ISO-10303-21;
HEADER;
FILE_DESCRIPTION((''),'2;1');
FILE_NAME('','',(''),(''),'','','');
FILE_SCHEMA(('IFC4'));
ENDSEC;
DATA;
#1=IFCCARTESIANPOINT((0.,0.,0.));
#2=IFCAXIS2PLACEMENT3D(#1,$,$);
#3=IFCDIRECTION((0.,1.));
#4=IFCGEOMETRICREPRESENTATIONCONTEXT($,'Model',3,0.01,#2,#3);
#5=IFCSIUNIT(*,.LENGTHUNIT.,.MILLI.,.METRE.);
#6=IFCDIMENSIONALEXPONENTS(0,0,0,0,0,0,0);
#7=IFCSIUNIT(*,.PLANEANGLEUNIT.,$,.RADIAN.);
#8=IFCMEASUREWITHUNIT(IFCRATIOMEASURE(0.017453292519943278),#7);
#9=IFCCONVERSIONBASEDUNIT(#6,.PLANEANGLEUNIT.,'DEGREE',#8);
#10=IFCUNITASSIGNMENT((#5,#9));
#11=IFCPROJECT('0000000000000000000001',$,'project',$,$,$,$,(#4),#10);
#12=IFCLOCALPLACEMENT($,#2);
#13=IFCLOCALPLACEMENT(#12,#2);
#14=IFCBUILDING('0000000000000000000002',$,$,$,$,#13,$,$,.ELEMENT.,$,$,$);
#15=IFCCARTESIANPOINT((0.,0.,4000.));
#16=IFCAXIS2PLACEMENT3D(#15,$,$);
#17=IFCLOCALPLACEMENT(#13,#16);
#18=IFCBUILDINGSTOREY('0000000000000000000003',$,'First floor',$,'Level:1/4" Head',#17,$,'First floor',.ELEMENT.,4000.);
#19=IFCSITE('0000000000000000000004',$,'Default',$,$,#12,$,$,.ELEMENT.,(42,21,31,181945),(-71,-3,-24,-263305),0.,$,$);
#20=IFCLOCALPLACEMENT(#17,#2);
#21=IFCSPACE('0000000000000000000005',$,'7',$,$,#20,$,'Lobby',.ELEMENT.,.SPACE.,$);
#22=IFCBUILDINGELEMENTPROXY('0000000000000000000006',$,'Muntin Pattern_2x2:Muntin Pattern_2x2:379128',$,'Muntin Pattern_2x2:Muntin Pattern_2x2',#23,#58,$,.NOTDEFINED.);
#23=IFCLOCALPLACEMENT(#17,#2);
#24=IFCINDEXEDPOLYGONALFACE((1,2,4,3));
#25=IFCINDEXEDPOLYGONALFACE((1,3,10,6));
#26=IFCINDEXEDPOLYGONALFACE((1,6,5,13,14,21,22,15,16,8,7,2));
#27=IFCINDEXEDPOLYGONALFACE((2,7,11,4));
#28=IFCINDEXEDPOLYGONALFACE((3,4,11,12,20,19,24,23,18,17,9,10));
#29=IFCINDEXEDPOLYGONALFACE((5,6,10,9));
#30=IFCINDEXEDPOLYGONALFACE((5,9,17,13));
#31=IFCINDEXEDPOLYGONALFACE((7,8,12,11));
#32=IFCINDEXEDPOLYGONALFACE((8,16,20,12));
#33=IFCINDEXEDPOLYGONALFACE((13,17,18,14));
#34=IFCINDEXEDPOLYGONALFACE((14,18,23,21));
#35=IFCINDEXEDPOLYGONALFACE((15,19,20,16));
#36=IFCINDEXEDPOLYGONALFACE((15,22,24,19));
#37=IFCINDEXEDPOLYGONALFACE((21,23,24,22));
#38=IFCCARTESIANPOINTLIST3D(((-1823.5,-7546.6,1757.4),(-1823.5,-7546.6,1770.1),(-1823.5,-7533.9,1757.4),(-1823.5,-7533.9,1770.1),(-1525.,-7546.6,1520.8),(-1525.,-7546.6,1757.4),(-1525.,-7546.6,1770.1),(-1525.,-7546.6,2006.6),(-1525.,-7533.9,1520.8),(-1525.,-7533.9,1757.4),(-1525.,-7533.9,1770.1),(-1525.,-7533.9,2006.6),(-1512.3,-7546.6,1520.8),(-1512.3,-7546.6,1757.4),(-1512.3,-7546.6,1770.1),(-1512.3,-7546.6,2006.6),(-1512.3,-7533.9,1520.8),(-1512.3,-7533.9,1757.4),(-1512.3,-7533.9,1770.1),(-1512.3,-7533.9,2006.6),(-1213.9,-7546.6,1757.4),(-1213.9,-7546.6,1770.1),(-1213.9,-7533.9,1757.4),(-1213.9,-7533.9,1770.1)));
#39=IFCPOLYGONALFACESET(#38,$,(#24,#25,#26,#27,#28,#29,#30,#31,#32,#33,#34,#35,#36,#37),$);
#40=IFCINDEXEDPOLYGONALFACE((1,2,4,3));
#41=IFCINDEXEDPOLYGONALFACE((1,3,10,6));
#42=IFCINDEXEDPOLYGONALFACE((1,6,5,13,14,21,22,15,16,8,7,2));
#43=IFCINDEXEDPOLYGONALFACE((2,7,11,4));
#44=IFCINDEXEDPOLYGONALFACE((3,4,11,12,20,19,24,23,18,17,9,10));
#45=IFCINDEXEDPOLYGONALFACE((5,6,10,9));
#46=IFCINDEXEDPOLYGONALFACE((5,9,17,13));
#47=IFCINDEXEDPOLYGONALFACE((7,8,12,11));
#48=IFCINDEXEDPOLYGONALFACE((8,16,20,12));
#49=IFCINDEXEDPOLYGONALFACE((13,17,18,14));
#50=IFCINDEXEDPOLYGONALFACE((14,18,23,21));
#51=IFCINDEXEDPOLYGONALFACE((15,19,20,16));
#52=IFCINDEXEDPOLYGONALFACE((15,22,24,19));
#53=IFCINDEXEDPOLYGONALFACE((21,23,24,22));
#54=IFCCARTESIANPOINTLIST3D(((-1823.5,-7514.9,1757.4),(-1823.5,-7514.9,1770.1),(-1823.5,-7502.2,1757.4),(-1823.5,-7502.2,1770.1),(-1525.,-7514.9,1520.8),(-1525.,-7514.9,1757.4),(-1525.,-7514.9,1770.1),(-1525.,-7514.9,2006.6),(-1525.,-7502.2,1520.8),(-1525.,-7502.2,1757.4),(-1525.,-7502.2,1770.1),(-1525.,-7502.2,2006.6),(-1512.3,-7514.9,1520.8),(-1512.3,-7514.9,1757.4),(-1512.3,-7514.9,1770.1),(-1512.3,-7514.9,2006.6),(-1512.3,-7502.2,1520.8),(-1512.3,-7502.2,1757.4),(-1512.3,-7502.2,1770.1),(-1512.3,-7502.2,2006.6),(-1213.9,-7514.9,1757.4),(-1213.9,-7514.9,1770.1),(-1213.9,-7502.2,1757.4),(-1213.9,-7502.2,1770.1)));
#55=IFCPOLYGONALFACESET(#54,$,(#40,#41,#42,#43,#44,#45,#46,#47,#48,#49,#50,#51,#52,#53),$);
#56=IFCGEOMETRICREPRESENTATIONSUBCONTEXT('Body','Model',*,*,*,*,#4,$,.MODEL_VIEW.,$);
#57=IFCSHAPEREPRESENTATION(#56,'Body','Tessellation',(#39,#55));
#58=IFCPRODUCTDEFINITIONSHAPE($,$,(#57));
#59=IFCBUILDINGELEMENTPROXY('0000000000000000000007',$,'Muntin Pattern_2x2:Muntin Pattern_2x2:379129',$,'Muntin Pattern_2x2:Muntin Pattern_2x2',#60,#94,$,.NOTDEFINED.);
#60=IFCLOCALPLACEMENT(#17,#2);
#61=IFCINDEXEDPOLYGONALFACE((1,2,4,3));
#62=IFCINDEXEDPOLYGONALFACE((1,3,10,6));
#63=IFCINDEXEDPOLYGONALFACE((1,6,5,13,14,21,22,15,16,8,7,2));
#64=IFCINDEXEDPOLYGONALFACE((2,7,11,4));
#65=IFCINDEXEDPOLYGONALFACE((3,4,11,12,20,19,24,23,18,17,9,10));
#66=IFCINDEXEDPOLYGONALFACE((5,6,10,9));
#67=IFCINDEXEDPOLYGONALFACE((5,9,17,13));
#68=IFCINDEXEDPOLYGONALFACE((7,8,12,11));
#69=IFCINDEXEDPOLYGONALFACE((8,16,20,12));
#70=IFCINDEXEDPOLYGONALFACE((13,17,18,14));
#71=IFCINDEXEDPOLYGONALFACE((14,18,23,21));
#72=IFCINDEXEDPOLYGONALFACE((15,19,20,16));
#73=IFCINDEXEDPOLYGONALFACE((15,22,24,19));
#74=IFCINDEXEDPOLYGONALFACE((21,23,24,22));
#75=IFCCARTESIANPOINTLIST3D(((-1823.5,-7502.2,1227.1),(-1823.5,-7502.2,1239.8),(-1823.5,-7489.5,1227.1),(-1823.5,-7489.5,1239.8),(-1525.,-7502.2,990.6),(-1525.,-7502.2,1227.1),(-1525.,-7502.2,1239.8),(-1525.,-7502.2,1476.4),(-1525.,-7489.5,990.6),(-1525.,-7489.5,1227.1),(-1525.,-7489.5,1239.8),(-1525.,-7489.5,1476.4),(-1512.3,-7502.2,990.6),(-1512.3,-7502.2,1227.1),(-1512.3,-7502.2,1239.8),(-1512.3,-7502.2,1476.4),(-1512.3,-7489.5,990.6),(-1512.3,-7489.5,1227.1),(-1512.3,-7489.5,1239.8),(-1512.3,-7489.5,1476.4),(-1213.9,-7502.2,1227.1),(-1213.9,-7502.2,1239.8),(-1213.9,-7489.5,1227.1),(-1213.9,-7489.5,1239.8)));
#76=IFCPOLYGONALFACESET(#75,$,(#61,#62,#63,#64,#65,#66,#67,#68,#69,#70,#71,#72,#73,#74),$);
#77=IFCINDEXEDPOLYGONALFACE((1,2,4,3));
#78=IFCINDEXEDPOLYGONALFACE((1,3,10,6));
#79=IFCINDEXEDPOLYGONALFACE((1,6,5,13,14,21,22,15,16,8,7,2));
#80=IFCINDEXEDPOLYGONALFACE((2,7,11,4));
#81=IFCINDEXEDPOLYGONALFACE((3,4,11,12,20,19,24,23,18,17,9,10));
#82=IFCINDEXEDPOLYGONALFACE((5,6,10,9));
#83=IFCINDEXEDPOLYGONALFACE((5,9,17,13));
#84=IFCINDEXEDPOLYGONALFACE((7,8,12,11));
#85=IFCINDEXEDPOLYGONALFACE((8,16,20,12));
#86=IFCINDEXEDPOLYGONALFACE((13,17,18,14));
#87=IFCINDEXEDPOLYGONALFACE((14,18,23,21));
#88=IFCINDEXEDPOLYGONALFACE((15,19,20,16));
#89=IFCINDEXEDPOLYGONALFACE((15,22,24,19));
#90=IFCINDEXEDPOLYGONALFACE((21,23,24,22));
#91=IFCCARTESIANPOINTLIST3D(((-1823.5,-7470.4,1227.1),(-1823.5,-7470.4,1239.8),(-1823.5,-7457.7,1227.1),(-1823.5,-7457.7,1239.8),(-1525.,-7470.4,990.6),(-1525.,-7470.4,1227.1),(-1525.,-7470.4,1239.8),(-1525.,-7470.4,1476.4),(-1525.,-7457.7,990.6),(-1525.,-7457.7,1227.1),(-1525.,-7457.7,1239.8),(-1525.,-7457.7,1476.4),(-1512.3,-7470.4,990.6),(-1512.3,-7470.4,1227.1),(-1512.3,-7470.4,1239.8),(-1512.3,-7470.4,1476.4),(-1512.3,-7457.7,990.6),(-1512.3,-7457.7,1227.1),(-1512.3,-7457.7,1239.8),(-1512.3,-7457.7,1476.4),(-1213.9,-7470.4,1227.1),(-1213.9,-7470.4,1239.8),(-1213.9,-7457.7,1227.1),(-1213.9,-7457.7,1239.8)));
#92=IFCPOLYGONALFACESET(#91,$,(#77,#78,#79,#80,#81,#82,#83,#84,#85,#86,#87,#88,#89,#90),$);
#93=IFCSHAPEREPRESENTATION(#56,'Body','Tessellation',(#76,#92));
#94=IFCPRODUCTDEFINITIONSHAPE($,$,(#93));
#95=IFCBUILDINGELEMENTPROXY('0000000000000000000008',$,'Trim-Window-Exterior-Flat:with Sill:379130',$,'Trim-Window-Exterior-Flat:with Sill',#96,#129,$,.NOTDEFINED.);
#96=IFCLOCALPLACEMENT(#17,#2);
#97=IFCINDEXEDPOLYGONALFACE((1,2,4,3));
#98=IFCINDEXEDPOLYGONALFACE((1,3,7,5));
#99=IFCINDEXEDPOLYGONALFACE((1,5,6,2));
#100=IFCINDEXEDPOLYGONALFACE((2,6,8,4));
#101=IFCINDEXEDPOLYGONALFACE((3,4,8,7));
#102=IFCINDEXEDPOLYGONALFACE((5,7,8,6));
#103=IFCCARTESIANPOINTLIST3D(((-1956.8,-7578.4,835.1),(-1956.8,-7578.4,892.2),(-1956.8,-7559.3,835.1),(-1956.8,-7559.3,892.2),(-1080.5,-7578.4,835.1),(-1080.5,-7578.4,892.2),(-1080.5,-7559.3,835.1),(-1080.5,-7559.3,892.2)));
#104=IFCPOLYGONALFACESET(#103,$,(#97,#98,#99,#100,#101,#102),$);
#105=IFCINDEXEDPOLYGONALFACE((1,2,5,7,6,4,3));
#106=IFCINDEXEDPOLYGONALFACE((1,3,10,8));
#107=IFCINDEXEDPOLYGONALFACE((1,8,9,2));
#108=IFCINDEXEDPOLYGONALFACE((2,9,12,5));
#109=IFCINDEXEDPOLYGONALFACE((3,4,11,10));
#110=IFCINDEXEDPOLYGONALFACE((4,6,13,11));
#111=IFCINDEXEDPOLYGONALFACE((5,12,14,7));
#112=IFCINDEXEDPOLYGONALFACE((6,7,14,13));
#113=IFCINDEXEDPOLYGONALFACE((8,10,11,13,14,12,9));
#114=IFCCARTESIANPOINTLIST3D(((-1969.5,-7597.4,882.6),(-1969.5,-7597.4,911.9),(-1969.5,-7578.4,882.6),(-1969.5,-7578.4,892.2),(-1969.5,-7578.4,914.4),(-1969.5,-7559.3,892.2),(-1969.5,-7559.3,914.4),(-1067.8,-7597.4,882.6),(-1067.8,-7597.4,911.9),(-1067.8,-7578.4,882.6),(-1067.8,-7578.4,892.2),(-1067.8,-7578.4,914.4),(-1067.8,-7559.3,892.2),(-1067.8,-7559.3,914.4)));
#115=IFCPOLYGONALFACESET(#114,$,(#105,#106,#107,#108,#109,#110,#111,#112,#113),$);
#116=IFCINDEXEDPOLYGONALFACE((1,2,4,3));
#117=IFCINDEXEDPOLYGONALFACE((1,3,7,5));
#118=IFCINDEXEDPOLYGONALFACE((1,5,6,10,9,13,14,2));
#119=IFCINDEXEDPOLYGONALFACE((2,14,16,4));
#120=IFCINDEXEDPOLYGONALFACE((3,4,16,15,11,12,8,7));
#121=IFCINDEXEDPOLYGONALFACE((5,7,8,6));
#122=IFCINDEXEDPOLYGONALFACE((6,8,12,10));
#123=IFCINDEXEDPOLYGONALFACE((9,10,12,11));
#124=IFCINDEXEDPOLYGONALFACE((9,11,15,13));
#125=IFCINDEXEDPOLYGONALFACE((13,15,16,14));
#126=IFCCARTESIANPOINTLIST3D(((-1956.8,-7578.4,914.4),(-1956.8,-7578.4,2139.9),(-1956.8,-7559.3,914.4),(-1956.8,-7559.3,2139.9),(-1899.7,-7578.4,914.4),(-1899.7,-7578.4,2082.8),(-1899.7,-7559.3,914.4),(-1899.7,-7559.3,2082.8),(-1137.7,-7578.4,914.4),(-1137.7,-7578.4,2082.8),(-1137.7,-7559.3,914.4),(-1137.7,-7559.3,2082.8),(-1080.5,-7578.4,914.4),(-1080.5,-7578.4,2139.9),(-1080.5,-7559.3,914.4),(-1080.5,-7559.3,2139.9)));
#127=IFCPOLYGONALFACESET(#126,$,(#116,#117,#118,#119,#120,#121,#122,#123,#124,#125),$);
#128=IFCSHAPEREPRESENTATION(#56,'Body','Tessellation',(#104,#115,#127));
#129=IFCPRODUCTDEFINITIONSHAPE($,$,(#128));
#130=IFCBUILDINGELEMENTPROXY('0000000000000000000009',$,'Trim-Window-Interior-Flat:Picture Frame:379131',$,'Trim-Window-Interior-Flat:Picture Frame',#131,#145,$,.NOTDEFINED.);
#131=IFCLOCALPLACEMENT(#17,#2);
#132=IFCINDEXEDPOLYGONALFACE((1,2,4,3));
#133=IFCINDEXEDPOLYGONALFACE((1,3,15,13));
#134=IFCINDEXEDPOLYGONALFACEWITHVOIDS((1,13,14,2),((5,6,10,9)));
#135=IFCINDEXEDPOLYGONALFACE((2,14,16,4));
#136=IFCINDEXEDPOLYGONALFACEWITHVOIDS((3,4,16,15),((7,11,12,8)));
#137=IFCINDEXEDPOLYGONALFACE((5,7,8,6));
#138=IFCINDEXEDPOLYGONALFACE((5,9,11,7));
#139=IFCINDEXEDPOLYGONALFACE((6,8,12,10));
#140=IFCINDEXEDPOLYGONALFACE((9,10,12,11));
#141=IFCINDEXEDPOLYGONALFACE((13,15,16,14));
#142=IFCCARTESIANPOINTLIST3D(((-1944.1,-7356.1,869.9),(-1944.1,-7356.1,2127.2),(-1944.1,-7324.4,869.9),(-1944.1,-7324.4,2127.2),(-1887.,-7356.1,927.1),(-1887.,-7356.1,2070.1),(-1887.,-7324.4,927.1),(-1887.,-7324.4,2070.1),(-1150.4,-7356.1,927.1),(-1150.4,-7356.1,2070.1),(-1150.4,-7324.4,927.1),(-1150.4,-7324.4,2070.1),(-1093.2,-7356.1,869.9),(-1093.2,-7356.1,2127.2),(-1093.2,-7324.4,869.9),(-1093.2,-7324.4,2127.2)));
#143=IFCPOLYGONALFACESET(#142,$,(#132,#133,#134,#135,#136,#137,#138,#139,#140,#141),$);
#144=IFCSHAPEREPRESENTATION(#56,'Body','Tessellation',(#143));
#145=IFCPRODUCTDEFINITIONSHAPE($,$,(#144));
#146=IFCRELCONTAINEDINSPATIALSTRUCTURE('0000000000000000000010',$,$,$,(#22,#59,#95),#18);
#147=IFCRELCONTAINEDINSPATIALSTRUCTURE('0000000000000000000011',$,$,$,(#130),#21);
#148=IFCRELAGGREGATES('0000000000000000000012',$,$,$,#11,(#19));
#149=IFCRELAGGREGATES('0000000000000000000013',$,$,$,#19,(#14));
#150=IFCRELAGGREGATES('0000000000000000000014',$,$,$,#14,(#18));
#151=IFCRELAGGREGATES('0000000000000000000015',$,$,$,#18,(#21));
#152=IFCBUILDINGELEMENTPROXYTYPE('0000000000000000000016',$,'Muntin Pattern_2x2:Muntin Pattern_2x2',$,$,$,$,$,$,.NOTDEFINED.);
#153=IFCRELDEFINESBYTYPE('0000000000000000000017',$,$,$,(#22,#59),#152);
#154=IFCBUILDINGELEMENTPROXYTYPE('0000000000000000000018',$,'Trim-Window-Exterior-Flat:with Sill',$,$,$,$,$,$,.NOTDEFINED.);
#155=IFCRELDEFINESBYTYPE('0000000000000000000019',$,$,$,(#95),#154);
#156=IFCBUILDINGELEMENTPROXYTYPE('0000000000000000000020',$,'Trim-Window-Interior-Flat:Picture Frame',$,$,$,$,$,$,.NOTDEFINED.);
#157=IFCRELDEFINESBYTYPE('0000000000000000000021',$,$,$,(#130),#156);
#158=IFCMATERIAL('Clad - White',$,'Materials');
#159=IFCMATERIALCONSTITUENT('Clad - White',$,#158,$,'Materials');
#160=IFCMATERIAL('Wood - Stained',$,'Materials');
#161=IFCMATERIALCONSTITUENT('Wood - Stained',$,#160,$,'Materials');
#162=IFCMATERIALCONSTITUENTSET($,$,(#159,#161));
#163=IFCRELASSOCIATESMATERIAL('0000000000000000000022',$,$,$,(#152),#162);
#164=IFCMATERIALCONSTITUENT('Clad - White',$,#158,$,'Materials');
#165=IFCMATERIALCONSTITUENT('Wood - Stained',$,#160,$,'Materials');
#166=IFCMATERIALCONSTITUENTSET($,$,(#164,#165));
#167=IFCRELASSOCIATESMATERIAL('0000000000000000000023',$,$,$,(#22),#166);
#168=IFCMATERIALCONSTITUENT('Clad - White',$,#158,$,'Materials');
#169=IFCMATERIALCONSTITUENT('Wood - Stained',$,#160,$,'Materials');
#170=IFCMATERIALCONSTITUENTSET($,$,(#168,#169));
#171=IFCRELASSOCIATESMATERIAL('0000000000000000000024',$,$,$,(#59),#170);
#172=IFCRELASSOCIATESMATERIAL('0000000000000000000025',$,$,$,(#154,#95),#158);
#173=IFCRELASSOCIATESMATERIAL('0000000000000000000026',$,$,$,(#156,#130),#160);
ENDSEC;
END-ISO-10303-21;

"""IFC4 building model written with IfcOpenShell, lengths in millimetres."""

from ifc_helpers import new_model, entity, si_unit, converted_unit, direction, frame, origin, place, context, subcontext, project, spatial, indexed_curve, outline, extrude, source, transform, mapped, material, constituent, constituent_set, type_object, type_shapes, element, save


model = new_model("IFC4")

# Units and contexts
model_context = context("Model", 3, precision=0.01, world=origin(), true_north=direction((0.0, 1.0)))
body_context = subcontext(model_context, "Body", "Model", "MODEL_VIEW")
ifc_project = project(units=[si_unit("LENGTHUNIT", "METRE", prefix="MILLI"), converted_unit("PLANEANGLEUNIT", "DEGREE", entity("IfcRatioMeasure", 0.017453292519943278), si_unit("PLANEANGLEUNIT", "RADIAN"), dimensions=[0, 0, 0, 0, 0, 0, 0])], contexts=[model_context])

# Site, building, storey
site_placement = place(None, origin())
site = spatial("IfcSite", under=ifc_project, at=site_placement, Name="Default", CompositionType="ELEMENT", RefLatitude=(42, 21, 31, 181945), RefLongitude=(-71, -3, -24, -263305), RefElevation=0.0)
building_placement = place(site_placement, origin())
building = spatial("IfcBuilding", under=site, at=building_placement, CompositionType="ELEMENT")
storey_placement = place(building_placement, frame((0.0, 0.0, 4000.0)))
storey = spatial("IfcBuildingStorey", under=building, at=storey_placement, Name="First floor", ObjectType="Level:1/4\" Head", LongName="First floor", CompositionType="ELEMENT", Elevation=4000.0)

# Shared definitions
ifc_material_1 = material(Name="Clad - White", Category="Materials")
ifc_material_2 = material(Name="Wood - Stained", Category="Materials")

# Shared definitions
space_1_placement = place(storey_placement, origin())
space_1 = spatial("IfcSpace", under=storey, at=space_1_placement, Name="7", LongName="Lobby", CompositionType="ELEMENT", PredefinedType="SPACE")

# Building element proxies
ifc_constituent_1 = constituent(ifc_material_1, Name="Clad - White", Category="Materials")
ifc_constituent_2 = constituent(ifc_material_2, Name="Wood - Stained", Category="Materials")
ifc_constituent_set_1 = constituent_set(constituents=[ifc_constituent_1, ifc_constituent_2])
ifc_constituent_3 = constituent(ifc_material_1, Name="Clad - White", Category="Materials")
ifc_constituent_4 = constituent(ifc_material_2, Name="Wood - Stained", Category="Materials")
ifc_constituent_set_2 = constituent_set(constituents=[ifc_constituent_3, ifc_constituent_4])
building_element_proxy_type_1 = type_object("IfcBuildingElementProxyType", Name="Muntin Pattern_2x2:Muntin Pattern_2x2", PredefinedType="NOTDEFINED", material=ifc_constituent_set_2)
shared_shape_1 = source(origin(), body_context, "Body", "SweptSolid", [
    extrude(outline(indexed_curve([(6.4, -6.4), (242.9, -6.4), (242.9, 6.3), (6.4, 6.3), (6.4, 304.8), (-6.3, 304.8), (-6.3, 6.3), (-242.9, 6.3), (-242.9, -6.4), (-6.3, -6.4), (-6.3, -304.8), (6.4, -304.8), (6.4, -6.4)], self_intersect=False)), frame((0.0, 9.5, 242.9), z_axis=(0.0, 1.0, 0.0), x_axis=(0.0, 0.0, 1.0)), (0.0, 0.0, 1.0), 12.7),
    extrude(outline(indexed_curve([(6.4, -6.4), (242.9, -6.4), (242.9, 6.3), (6.4, 6.3), (6.4, 304.8), (-6.3, 304.8), (-6.3, 6.3), (-242.9, 6.3), (-242.9, -6.4), (-6.3, -6.4), (-6.3, -304.8), (6.4, -304.8), (6.4, -6.4)], self_intersect=False)), frame((0.0, -22.2, 242.9), z_axis=(0.0, 1.0, 0.0), x_axis=(0.0, 0.0, 1.0)), (0.0, 0.0, 1.0), 12.7),
])
type_shapes(building_element_proxy_type_1, [shared_shape_1])
proxy_1_placement = place(storey_placement, frame((-1518.7, -7524.4, 1520.8), z_axis=(0.0, 0.0, 1.0), x_axis=(-1.0, 0.0, 0.0)))
element("IfcBuildingElementProxy", 1, at=proxy_1_placement, inside=storey, type_object=building_element_proxy_type_1, material=ifc_constituent_set_1, Name="Muntin Pattern_2x2:Muntin Pattern_2x2:379128", ObjectType="Muntin Pattern_2x2:Muntin Pattern_2x2", PredefinedType="NOTDEFINED", context=body_context, shape_type="MappedRepresentation", body=[
    mapped(shared_shape_1, transform((0.0, 0.0, 0.0), scale=1.0)),
])
ifc_constituent_5 = constituent(ifc_material_1, Name="Clad - White", Category="Materials")
ifc_constituent_6 = constituent(ifc_material_2, Name="Wood - Stained", Category="Materials")
ifc_constituent_set_3 = constituent_set(constituents=[ifc_constituent_5, ifc_constituent_6])
proxy_2_placement = place(storey_placement, frame((-1518.7, -7480.0, 990.6), z_axis=(0.0, 0.0, 1.0), x_axis=(-1.0, 0.0, 0.0)))
element("IfcBuildingElementProxy", 2, at=proxy_2_placement, inside=storey, type_object=building_element_proxy_type_1, material=ifc_constituent_set_3, Name="Muntin Pattern_2x2:Muntin Pattern_2x2:379129", ObjectType="Muntin Pattern_2x2:Muntin Pattern_2x2", PredefinedType="NOTDEFINED", context=body_context, shape_type="MappedRepresentation", body=[
    mapped(shared_shape_1, transform((0.0, 0.0, 0.0), scale=1.0)),
])
building_element_proxy_type_2 = type_object("IfcBuildingElementProxyType", Name="Trim-Window-Exterior-Flat:with Sill", PredefinedType="NOTDEFINED", material=ifc_material_1)
shared_shape_2 = source(origin(), body_context, "Body", "SweptSolid", [
    extrude(outline(indexed_curve([(-438.1, -28.6), (438.1, -28.6), (438.1, 28.6), (-438.1, 28.6), (-438.1, -28.6)], self_intersect=False)), frame((0.0, -1219.2, 0.0), z_axis=(0.0, 0.0, 1.0), x_axis=(-1.0, 0.0, 0.0)), (0.0, 0.0, 1.0), 19.0),
    extrude(outline(indexed_curve([(-19.0, -16.0), (0.0, -16.0), (0.0, -6.4), (19.0, -6.4), (19.0, 15.8), (0.0, 15.8), (-19.0, 13.3), (-19.0, -16.0)], self_intersect=False)), frame((-450.8, -1184.2, 19.0), z_axis=(1.0, 0.0, 0.0), x_axis=(0.0, 0.0, -1.0)), (0.0, 0.0, 1.0), 901.7),
    extrude(outline(indexed_curve([(-627.1, -438.1), (598.5, -438.1), (598.5, -381.0), (-569.9, -381.0), (-569.9, 381.0), (598.5, 381.0), (598.5, 438.1), (-627.1, 438.1), (-627.1, -438.1)], self_intersect=False)), frame((0.0, -569.9, 0.0), z_axis=(0.0, 0.0, 1.0), x_axis=(0.0, -1.0, 0.0)), (0.0, 0.0, 1.0), 19.0),
])
type_shapes(building_element_proxy_type_2, [shared_shape_2])
proxy_3_placement = place(storey_placement, frame((-1518.7, -7559.3, 2082.8), z_axis=(0.0, -1.0, 0.0), x_axis=(1.0, 0.0, 0.0)))
element("IfcBuildingElementProxy", 3, at=proxy_3_placement, inside=storey, type_object=building_element_proxy_type_2, material=ifc_material_1, Name="Trim-Window-Exterior-Flat:with Sill:379130", ObjectType="Trim-Window-Exterior-Flat:with Sill", PredefinedType="NOTDEFINED", context=body_context, shape_type="MappedRepresentation", body=[
    mapped(shared_shape_2, transform((0.0, 0.0, 0.0), scale=1.0)),
])
building_element_proxy_type_3 = type_object("IfcBuildingElementProxyType", Name="Trim-Window-Interior-Flat:Picture Frame", PredefinedType="NOTDEFINED", material=ifc_material_2)
shared_shape_3 = source(origin(), body_context, "Body", "SweptSolid", [
    extrude(outline(indexed_curve([(-425.4, -628.6), (425.4, -628.6), (425.4, 628.6), (-425.4, 628.6), (-425.4, -628.6)], self_intersect=False), holes=[indexed_curve([(-368.3, -571.5), (-368.3, 571.5), (368.3, 571.5), (368.3, -571.5), (-368.3, -571.5)], self_intersect=False)]), frame((0.0, -584.2, 0.0), z_axis=(0.0, 0.0, 1.0), x_axis=(-1.0, 0.0, 0.0)), (0.0, 0.0, 1.0), 31.7),
])
type_shapes(building_element_proxy_type_3, [shared_shape_3])
proxy_4_placement = place(space_1_placement, frame((-1518.7, -7356.1, 2082.8), z_axis=(0.0, 1.0, 0.0), x_axis=(-1.0, 0.0, 0.0)))
element("IfcBuildingElementProxy", 4, at=proxy_4_placement, inside=space_1, type_object=building_element_proxy_type_3, material=ifc_material_2, Name="Trim-Window-Interior-Flat:Picture Frame:379131", ObjectType="Trim-Window-Interior-Flat:Picture Frame", PredefinedType="NOTDEFINED", context=body_context, shape_type="MappedRepresentation", body=[
    mapped(shared_shape_3, transform((0.0, 0.0, 0.0), scale=1.0)),
])

save(model, "model.ifc")
